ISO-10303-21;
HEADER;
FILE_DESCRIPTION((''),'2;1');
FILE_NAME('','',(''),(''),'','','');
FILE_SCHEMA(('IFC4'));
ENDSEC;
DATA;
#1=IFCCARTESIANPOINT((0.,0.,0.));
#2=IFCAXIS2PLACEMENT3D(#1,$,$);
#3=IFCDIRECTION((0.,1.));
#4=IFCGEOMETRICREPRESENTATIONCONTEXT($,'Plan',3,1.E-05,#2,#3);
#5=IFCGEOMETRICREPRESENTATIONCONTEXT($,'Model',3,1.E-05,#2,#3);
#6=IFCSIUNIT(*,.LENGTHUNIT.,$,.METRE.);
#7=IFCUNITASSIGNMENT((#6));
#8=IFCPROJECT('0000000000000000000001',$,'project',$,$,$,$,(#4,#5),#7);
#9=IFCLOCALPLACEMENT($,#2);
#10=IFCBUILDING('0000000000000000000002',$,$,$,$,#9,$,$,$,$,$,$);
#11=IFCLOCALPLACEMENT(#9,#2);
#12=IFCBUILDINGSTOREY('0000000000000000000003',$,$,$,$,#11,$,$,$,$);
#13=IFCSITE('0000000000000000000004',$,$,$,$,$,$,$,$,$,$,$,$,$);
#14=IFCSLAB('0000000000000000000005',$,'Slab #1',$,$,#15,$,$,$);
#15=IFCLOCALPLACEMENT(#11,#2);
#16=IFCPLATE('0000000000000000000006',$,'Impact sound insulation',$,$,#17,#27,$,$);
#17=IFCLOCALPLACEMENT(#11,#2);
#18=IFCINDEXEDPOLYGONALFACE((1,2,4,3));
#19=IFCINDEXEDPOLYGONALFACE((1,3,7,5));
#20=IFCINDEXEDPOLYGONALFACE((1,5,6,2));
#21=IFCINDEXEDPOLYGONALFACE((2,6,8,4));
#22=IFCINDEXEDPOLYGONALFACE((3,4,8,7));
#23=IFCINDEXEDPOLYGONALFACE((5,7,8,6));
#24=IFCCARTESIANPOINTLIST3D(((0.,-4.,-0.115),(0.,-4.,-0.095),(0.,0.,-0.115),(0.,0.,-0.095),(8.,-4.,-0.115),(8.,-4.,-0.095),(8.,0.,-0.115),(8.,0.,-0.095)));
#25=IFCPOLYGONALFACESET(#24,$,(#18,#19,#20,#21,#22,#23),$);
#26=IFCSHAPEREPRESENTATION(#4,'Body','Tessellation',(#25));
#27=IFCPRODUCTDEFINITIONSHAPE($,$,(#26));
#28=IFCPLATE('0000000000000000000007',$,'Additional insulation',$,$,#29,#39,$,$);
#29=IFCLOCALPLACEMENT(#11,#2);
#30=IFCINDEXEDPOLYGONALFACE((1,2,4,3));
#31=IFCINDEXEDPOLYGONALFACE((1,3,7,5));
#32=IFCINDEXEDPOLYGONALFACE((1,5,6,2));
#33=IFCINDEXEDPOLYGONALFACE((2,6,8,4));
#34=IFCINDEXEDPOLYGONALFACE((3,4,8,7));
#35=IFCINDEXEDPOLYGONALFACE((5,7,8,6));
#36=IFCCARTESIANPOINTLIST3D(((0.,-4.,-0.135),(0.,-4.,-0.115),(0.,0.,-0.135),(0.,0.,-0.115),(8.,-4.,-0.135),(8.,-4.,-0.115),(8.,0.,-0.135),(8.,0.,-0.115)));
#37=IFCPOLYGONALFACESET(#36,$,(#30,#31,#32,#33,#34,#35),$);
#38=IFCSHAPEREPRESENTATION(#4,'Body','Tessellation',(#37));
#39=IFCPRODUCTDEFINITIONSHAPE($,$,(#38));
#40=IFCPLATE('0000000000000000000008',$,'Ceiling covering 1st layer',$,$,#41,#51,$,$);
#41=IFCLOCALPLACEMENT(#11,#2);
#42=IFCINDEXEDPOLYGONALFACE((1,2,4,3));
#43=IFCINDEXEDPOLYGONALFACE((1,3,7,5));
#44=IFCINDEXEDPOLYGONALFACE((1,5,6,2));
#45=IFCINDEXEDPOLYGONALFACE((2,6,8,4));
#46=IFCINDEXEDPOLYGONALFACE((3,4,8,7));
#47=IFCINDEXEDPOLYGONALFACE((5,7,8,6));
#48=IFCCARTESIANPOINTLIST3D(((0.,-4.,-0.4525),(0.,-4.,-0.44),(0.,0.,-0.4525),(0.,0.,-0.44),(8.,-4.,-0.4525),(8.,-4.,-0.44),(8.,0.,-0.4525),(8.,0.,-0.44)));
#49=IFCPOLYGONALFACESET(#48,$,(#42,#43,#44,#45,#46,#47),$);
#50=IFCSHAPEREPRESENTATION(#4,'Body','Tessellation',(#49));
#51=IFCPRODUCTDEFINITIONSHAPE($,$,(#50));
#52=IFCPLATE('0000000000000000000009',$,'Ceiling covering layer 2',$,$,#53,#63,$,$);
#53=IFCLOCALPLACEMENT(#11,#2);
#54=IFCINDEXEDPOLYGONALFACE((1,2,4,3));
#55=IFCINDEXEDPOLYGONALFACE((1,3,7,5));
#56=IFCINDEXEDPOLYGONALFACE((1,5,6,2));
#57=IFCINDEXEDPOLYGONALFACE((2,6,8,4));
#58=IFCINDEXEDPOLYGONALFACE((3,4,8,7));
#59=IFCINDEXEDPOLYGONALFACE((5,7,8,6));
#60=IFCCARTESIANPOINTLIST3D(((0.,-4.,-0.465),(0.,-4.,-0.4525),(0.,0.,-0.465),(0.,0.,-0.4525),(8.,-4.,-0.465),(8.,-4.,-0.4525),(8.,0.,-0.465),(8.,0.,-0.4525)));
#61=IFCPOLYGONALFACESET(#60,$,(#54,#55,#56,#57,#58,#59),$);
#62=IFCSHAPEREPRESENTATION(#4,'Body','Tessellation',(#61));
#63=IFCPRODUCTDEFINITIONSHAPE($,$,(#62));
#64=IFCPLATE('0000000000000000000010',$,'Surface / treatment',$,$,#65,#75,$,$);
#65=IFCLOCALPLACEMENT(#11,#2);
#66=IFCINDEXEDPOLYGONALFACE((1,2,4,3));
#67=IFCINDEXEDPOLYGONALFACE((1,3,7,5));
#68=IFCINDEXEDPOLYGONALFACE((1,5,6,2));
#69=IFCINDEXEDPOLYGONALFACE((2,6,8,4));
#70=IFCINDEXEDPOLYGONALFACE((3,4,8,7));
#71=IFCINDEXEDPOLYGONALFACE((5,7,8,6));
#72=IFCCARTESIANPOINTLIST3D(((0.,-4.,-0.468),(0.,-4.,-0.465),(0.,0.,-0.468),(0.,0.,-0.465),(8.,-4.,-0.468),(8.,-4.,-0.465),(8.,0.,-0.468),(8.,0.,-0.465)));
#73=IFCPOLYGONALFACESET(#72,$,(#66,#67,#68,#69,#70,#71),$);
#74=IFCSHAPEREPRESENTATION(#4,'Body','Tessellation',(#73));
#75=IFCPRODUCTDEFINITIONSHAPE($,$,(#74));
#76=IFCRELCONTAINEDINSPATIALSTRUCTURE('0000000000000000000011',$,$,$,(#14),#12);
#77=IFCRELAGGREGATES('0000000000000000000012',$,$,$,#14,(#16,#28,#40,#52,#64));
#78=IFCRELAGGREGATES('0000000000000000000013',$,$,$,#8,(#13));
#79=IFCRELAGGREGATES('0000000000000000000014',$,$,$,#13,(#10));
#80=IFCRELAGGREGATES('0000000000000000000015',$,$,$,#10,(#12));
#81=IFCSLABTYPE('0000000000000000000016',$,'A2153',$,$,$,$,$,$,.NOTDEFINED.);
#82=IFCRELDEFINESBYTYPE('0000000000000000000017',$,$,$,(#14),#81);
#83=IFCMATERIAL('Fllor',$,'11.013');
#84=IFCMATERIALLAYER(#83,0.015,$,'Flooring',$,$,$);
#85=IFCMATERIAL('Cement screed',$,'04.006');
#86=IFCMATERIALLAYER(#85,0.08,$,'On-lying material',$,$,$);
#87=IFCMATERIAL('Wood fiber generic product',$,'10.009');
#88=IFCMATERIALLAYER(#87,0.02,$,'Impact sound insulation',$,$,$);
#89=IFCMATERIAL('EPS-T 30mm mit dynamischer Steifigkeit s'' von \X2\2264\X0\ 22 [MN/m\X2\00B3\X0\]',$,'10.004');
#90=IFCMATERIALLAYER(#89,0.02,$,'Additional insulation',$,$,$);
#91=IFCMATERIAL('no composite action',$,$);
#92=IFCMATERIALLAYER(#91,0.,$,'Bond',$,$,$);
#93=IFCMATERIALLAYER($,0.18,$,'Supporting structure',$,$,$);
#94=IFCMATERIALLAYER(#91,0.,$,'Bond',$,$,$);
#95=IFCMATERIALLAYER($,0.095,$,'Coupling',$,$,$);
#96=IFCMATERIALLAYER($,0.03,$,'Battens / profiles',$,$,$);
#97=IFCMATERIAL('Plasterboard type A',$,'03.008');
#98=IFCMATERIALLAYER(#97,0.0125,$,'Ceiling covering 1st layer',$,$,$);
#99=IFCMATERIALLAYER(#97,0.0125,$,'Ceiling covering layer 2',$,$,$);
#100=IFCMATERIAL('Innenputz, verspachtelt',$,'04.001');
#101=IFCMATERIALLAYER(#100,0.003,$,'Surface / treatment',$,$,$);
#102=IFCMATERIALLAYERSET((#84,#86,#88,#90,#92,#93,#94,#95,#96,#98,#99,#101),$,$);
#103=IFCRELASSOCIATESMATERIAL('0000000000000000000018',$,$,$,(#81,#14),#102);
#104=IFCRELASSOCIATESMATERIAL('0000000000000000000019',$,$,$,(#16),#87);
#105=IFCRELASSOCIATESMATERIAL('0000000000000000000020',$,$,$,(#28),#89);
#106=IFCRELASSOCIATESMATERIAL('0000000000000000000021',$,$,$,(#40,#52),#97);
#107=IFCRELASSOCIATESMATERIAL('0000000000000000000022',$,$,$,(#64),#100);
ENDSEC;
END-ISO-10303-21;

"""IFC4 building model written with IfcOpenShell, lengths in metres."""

from ifc_helpers import new_model, si_unit, direction, frame, frame_2d, origin, place, context, project, spatial, rectangle, extrude, material, layer, layer_set, type_object, element, aggregate, save


model = new_model("IFC4")

# Units and contexts
plan_context = context("Plan", 3, precision=1e-05, world=origin(), true_north=direction((0.0, 1.0)))
model_context = context("Model", 3, precision=1e-05, world=origin(), true_north=direction((0.0, 1.0)))
ifc_project = project(units=[si_unit("LENGTHUNIT", "METRE")], contexts=[plan_context, model_context])

# Site, building, storey
site = spatial("IfcSite", under=ifc_project)
building_placement = place(None, origin())
building = spatial("IfcBuilding", under=site, at=building_placement)
storey_placement = place(building_placement, origin())
storey = spatial("IfcBuildingStorey", under=building, at=storey_placement)

# Slab, plates
ifc_material_1 = material(Name="Fllor", Category="11.013")
ifc_layer_1 = layer(ifc_material_1, 0.015, Name="Flooring")
ifc_material_2 = material(Name="Cement screed", Category="04.006")
ifc_layer_2 = layer(ifc_material_2, 0.08, Name="On-lying material")
ifc_material_3 = material(Name="Wood fiber generic product", Category="10.009")
ifc_layer_3 = layer(ifc_material_3, 0.02, Name="Impact sound insulation")
ifc_material_4 = material(Name="EPS-T 30mm mit dynamischer Steifigkeit s' von ≤ 22 [MN/m³]", Category="10.004")
ifc_layer_4 = layer(ifc_material_4, 0.02, Name="Additional insulation")
ifc_material_5 = material(Name="no composite action")
ifc_layer_5 = layer(ifc_material_5, 0.0, Name="Bond")
ifc_layer_6 = layer(None, 0.18, Name="Supporting structure")
ifc_layer_7 = layer(ifc_material_5, 0.0, Name="Bond")
ifc_layer_8 = layer(None, 0.095, Name="Coupling")
ifc_layer_9 = layer(None, 0.03, Name="Battens / profiles")
ifc_material_6 = material(Name="Plasterboard type A", Category="03.008")
ifc_layer_10 = layer(ifc_material_6, 0.0125, Name="Ceiling covering 1st layer")
ifc_layer_11 = layer(ifc_material_6, 0.0125, Name="Ceiling covering layer 2")
ifc_material_7 = material(Name="Innenputz, verspachtelt", Category="04.001")
ifc_layer_12 = layer(ifc_material_7, 0.003, Name="Surface / treatment")
ifc_layer_set = layer_set([ifc_layer_1, ifc_layer_2, ifc_layer_3, ifc_layer_4, ifc_layer_5, ifc_layer_6, ifc_layer_7, ifc_layer_8, ifc_layer_9, ifc_layer_10, ifc_layer_11, ifc_layer_12])
slab_type = type_object("IfcSlabType", Name="A2153", PredefinedType="NOTDEFINED", material=ifc_layer_set)
slab_placement = place(None, frame((0.0, 0.0, 0.0), z_axis=(0.0, 0.0, -1.0), x_axis=(1.0, 0.0, 0.0)))
slab = element("IfcSlab", 1, at=slab_placement, inside=storey, type_object=slab_type, material=ifc_layer_set, Name="Slab #1")
plate_1_placement = place(slab_placement, origin())
plate_1 = element("IfcPlate", 2, at=plate_1_placement, material=ifc_material_3, Name="Impact sound insulation", context=plan_context, shape_type="SweptSolid", body=[
    extrude(rectangle(XDim=8.0, YDim=4.0, at=frame_2d((4.0, 2.0), x_axis=(1.0, 0.0))), frame((0.0, 0.0, 0.095), z_axis=(0.0, 0.0, 1.0), x_axis=(1.0, 0.0, 0.0)), (0.0, 0.0, 1.0), 0.02),
])
plate_2_placement = place(slab_placement, origin())
plate_2 = element("IfcPlate", 3, at=plate_2_placement, material=ifc_material_4, Name="Additional insulation", context=plan_context, shape_type="SweptSolid", body=[
    extrude(rectangle(XDim=8.0, YDim=4.0, at=frame_2d((4.0, 2.0), x_axis=(1.0, 0.0))), frame((0.0, 0.0, 0.115), z_axis=(0.0, 0.0, 1.0), x_axis=(1.0, 0.0, 0.0)), (0.0, 0.0, 1.0), 0.02),
])
plate_3_placement = place(slab_placement, origin())
plate_3 = element("IfcPlate", 4, at=plate_3_placement, material=ifc_material_6, Name="Ceiling covering 1st layer", context=plan_context, shape_type="SweptSolid", body=[
    extrude(rectangle(XDim=8.0, YDim=4.0, at=frame_2d((4.0, 2.0), x_axis=(1.0, 0.0))), frame((0.0, 0.0, 0.44), z_axis=(0.0, 0.0, 1.0), x_axis=(1.0, 0.0, 0.0)), (0.0, 0.0, 1.0), 0.0125),
])
plate_4_placement = place(slab_placement, origin())
plate_4 = element("IfcPlate", 5, at=plate_4_placement, material=ifc_material_6, Name="Ceiling covering layer 2", context=plan_context, shape_type="SweptSolid", body=[
    extrude(rectangle(XDim=8.0, YDim=4.0, at=frame_2d((4.0, 2.0), x_axis=(1.0, 0.0))), frame((0.0, 0.0, 0.4525), z_axis=(0.0, 0.0, 1.0), x_axis=(1.0, 0.0, 0.0)), (0.0, 0.0, 1.0), 0.0125),
])
plate_5_placement = place(slab_placement, origin())
plate_5 = element("IfcPlate", 6, at=plate_5_placement, material=ifc_material_7, Name="Surface / treatment", context=plan_context, shape_type="SweptSolid", body=[
    extrude(rectangle(XDim=8.0, YDim=4.0, at=frame_2d((4.0, 2.0), x_axis=(1.0, 0.0))), frame((0.0, 0.0, 0.465), z_axis=(0.0, 0.0, 1.0), x_axis=(1.0, 0.0, 0.0)), (0.0, 0.0, 1.0), 0.003),
])
aggregate(slab, [plate_1, plate_2, plate_3, plate_4, plate_5])

save(model, "model.ifc")
